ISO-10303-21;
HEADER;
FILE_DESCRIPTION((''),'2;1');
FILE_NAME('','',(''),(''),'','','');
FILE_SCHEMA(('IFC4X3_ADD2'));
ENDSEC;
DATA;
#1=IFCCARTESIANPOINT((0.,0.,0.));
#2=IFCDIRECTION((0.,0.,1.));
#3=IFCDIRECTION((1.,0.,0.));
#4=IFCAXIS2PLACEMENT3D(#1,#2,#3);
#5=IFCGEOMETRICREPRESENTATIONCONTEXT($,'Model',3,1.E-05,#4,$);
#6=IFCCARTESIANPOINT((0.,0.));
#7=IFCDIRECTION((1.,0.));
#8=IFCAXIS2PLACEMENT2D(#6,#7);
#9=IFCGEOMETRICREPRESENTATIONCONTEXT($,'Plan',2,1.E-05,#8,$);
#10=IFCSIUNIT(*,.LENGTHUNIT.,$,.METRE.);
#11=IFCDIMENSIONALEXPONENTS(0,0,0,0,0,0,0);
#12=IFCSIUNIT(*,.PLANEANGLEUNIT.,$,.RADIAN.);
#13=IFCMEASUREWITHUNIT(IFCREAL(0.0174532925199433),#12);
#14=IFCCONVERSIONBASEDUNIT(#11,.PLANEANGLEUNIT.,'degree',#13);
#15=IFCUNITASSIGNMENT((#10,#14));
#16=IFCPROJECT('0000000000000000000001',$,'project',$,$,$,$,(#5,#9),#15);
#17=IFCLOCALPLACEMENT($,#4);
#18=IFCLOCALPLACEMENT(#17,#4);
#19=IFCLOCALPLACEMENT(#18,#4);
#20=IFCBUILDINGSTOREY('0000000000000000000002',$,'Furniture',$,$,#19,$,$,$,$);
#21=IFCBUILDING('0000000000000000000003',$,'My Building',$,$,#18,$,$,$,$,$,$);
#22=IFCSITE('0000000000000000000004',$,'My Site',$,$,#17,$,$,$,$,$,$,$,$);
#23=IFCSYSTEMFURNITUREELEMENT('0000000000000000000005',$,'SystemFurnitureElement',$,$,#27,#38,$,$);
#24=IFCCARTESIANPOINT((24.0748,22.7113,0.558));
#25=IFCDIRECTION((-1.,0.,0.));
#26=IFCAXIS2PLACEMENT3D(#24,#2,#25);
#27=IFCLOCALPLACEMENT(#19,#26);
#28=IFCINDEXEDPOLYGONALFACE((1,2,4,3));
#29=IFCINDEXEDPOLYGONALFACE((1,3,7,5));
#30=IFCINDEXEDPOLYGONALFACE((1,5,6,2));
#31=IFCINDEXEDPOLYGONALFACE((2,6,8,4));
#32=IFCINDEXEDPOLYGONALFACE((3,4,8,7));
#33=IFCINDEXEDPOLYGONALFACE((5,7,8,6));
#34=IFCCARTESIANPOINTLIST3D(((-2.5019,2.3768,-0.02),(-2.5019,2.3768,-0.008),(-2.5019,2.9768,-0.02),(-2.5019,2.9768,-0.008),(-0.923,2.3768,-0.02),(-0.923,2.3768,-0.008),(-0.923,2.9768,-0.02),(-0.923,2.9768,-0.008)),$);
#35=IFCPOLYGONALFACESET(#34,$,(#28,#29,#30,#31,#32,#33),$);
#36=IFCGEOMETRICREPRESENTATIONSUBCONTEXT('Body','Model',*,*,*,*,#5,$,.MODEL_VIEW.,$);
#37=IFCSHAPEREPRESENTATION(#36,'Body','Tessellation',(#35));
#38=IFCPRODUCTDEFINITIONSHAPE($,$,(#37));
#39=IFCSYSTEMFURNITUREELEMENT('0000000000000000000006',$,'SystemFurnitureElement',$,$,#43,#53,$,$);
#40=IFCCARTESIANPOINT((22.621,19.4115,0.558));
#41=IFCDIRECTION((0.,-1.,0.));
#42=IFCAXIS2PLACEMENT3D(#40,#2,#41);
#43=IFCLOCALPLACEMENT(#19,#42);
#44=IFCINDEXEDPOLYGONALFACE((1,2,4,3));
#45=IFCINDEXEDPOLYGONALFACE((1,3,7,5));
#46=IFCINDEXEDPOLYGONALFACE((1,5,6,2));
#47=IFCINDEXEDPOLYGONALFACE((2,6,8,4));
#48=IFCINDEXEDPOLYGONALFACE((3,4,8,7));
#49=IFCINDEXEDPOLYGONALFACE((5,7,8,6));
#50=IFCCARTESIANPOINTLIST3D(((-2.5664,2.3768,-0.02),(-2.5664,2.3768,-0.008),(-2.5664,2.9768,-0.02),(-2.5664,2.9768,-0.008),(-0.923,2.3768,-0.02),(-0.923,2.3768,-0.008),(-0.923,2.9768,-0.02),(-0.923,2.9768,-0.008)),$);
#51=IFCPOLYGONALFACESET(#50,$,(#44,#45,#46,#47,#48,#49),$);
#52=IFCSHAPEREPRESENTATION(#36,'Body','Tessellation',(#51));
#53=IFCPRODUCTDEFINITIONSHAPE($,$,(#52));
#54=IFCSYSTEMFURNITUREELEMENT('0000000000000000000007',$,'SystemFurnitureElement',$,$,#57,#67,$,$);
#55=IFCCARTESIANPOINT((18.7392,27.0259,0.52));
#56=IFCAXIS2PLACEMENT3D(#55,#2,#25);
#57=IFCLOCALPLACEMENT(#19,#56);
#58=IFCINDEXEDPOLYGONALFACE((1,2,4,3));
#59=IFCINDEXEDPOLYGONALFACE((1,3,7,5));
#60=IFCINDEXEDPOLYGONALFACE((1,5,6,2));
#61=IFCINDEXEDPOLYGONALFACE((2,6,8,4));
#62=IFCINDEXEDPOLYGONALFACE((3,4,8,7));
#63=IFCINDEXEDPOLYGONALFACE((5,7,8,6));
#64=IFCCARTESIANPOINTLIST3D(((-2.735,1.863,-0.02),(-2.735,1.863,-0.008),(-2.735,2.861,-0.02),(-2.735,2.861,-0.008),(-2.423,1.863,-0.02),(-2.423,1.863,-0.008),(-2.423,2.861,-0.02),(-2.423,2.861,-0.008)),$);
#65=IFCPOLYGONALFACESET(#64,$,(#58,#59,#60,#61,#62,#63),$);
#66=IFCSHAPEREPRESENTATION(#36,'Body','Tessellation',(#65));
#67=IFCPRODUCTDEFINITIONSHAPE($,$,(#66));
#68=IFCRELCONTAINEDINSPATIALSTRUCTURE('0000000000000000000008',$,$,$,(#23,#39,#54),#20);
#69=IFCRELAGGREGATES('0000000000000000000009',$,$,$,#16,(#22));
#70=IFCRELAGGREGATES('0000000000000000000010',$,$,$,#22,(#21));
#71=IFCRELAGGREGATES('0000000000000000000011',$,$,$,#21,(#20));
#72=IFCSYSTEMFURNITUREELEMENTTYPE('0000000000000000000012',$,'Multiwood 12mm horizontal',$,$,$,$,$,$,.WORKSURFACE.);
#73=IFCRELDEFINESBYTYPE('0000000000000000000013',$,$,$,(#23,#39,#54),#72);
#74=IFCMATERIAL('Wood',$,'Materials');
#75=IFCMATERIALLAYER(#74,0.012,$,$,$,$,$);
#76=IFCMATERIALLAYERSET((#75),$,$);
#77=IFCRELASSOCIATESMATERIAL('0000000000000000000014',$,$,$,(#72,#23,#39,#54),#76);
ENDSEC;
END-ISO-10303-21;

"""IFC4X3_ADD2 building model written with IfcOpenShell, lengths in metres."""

from ifc_helpers import new_model, entity, si_unit, converted_unit, frame, origin_with_axes, origin_2d_with_axis, place, context, subcontext, project, spatial, indexed_curve, outline, extrude, material, layer, layer_set, layer_usage, type_object, element, save


model = new_model("IFC4X3_ADD2")

# Units and contexts
model_context = context("Model", 3, precision=1e-05, world=origin_with_axes())
plan_context = context("Plan", 2, precision=1e-05, world=origin_2d_with_axis())
body_context = subcontext(model_context, "Body", "Model", "MODEL_VIEW")
ifc_project = project(units=[si_unit("LENGTHUNIT", "METRE"), converted_unit("PLANEANGLEUNIT", "degree", entity("IfcReal", 0.0174532925199433), si_unit("PLANEANGLEUNIT", "RADIAN"), dimensions=[0, 0, 0, 0, 0, 0, 0])], contexts=[model_context, plan_context])

# Site, building, storey
site_placement = place(None, origin_with_axes())
site = spatial("IfcSite", under=ifc_project, at=site_placement, Name="My Site")
building_placement = place(site_placement, origin_with_axes())
building = spatial("IfcBuilding", under=site, at=building_placement, Name="My Building")
storey_placement = place(building_placement, origin_with_axes())
storey = spatial("IfcBuildingStorey", under=building, at=storey_placement, Name="Furniture")

# System furniture elements
ifc_material = material(Name="Wood", Category="Materials")
ifc_layer_1 = layer(ifc_material, 0.012)
ifc_layer_set_1 = layer_set([ifc_layer_1])
ifc_layer_usage_1 = layer_usage(ifc_layer_set_1, "AXIS3", "POSITIVE", -0.02)
system_furniture_element_type_1 = type_object("IfcSystemFurnitureElementType", Name="Multiwood 12mm horizontal", PredefinedType="WORKSURFACE", material=ifc_layer_set_1)
system_furniture_element_1_placement = place(storey_placement, frame((24.0748, 22.7113, 0.558), z_axis=(0.0, 0.0, 1.0), x_axis=(-1.0, 0.0, 0.0)))
element("IfcSystemFurnitureElement", 1, at=system_furniture_element_1_placement, inside=storey, type_object=system_furniture_element_type_1, material=ifc_layer_usage_1, Name="SystemFurnitureElement", context=body_context, shape_type="SweptSolid", body=[
    extrude(outline(indexed_curve([(-2.5019, 2.9768), (-2.5019, 2.3768), (-0.923, 2.3768), (-0.923, 2.9768), (-2.5019, 2.9768)])), frame((0.0, 0.0, -0.02), z_axis=(0.0, 0.0, 1.0), x_axis=(1.0, 0.0, 0.0)), (0.0, 0.0, 1.0), 0.012),
])
ifc_layer_usage_2 = layer_usage(ifc_layer_set_1, "AXIS3", "POSITIVE", -0.02)
system_furniture_element_2_placement = place(storey_placement, frame((22.621, 19.4115, 0.558), z_axis=(0.0, 0.0, 1.0), x_axis=(0.0, -1.0, 0.0)))
element("IfcSystemFurnitureElement", 2, at=system_furniture_element_2_placement, inside=storey, type_object=system_furniture_element_type_1, material=ifc_layer_usage_2, Name="SystemFurnitureElement", context=body_context, shape_type="SweptSolid", body=[
    extrude(outline(indexed_curve([(-0.923, 2.9768), (-0.923, 2.3768), (-2.5664, 2.3768), (-2.5664, 2.9768), (-0.923, 2.9768)])), frame((0.0, 0.0, -0.02), z_axis=(0.0, 0.0, 1.0), x_axis=(1.0, 0.0, 0.0)), (0.0, 0.0, 1.0), 0.012),
])
ifc_layer_usage_3 = layer_usage(ifc_layer_set_1, "AXIS3", "POSITIVE", -0.02)
system_furniture_element_3_placement = place(storey_placement, frame((18.7392, 27.0259, 0.52), z_axis=(0.0, 0.0, 1.0), x_axis=(-1.0, 0.0, 0.0)))
element("IfcSystemFurnitureElement", 3, at=system_furniture_element_3_placement, inside=storey, type_object=system_furniture_element_type_1, material=ifc_layer_usage_3, Name="SystemFurnitureElement", context=body_context, shape_type="SweptSolid", body=[
    extrude(outline(indexed_curve([(-2.423, 2.861), (-2.423, 1.863), (-2.735, 1.863), (-2.735, 2.861), (-2.423, 2.861)])), frame((0.0, 0.0, -0.02), z_axis=(0.0, 0.0, 1.0), x_axis=(1.0, 0.0, 0.0)), (0.0, 0.0, 1.0), 0.012),
])

save(model, "model.ifc")
